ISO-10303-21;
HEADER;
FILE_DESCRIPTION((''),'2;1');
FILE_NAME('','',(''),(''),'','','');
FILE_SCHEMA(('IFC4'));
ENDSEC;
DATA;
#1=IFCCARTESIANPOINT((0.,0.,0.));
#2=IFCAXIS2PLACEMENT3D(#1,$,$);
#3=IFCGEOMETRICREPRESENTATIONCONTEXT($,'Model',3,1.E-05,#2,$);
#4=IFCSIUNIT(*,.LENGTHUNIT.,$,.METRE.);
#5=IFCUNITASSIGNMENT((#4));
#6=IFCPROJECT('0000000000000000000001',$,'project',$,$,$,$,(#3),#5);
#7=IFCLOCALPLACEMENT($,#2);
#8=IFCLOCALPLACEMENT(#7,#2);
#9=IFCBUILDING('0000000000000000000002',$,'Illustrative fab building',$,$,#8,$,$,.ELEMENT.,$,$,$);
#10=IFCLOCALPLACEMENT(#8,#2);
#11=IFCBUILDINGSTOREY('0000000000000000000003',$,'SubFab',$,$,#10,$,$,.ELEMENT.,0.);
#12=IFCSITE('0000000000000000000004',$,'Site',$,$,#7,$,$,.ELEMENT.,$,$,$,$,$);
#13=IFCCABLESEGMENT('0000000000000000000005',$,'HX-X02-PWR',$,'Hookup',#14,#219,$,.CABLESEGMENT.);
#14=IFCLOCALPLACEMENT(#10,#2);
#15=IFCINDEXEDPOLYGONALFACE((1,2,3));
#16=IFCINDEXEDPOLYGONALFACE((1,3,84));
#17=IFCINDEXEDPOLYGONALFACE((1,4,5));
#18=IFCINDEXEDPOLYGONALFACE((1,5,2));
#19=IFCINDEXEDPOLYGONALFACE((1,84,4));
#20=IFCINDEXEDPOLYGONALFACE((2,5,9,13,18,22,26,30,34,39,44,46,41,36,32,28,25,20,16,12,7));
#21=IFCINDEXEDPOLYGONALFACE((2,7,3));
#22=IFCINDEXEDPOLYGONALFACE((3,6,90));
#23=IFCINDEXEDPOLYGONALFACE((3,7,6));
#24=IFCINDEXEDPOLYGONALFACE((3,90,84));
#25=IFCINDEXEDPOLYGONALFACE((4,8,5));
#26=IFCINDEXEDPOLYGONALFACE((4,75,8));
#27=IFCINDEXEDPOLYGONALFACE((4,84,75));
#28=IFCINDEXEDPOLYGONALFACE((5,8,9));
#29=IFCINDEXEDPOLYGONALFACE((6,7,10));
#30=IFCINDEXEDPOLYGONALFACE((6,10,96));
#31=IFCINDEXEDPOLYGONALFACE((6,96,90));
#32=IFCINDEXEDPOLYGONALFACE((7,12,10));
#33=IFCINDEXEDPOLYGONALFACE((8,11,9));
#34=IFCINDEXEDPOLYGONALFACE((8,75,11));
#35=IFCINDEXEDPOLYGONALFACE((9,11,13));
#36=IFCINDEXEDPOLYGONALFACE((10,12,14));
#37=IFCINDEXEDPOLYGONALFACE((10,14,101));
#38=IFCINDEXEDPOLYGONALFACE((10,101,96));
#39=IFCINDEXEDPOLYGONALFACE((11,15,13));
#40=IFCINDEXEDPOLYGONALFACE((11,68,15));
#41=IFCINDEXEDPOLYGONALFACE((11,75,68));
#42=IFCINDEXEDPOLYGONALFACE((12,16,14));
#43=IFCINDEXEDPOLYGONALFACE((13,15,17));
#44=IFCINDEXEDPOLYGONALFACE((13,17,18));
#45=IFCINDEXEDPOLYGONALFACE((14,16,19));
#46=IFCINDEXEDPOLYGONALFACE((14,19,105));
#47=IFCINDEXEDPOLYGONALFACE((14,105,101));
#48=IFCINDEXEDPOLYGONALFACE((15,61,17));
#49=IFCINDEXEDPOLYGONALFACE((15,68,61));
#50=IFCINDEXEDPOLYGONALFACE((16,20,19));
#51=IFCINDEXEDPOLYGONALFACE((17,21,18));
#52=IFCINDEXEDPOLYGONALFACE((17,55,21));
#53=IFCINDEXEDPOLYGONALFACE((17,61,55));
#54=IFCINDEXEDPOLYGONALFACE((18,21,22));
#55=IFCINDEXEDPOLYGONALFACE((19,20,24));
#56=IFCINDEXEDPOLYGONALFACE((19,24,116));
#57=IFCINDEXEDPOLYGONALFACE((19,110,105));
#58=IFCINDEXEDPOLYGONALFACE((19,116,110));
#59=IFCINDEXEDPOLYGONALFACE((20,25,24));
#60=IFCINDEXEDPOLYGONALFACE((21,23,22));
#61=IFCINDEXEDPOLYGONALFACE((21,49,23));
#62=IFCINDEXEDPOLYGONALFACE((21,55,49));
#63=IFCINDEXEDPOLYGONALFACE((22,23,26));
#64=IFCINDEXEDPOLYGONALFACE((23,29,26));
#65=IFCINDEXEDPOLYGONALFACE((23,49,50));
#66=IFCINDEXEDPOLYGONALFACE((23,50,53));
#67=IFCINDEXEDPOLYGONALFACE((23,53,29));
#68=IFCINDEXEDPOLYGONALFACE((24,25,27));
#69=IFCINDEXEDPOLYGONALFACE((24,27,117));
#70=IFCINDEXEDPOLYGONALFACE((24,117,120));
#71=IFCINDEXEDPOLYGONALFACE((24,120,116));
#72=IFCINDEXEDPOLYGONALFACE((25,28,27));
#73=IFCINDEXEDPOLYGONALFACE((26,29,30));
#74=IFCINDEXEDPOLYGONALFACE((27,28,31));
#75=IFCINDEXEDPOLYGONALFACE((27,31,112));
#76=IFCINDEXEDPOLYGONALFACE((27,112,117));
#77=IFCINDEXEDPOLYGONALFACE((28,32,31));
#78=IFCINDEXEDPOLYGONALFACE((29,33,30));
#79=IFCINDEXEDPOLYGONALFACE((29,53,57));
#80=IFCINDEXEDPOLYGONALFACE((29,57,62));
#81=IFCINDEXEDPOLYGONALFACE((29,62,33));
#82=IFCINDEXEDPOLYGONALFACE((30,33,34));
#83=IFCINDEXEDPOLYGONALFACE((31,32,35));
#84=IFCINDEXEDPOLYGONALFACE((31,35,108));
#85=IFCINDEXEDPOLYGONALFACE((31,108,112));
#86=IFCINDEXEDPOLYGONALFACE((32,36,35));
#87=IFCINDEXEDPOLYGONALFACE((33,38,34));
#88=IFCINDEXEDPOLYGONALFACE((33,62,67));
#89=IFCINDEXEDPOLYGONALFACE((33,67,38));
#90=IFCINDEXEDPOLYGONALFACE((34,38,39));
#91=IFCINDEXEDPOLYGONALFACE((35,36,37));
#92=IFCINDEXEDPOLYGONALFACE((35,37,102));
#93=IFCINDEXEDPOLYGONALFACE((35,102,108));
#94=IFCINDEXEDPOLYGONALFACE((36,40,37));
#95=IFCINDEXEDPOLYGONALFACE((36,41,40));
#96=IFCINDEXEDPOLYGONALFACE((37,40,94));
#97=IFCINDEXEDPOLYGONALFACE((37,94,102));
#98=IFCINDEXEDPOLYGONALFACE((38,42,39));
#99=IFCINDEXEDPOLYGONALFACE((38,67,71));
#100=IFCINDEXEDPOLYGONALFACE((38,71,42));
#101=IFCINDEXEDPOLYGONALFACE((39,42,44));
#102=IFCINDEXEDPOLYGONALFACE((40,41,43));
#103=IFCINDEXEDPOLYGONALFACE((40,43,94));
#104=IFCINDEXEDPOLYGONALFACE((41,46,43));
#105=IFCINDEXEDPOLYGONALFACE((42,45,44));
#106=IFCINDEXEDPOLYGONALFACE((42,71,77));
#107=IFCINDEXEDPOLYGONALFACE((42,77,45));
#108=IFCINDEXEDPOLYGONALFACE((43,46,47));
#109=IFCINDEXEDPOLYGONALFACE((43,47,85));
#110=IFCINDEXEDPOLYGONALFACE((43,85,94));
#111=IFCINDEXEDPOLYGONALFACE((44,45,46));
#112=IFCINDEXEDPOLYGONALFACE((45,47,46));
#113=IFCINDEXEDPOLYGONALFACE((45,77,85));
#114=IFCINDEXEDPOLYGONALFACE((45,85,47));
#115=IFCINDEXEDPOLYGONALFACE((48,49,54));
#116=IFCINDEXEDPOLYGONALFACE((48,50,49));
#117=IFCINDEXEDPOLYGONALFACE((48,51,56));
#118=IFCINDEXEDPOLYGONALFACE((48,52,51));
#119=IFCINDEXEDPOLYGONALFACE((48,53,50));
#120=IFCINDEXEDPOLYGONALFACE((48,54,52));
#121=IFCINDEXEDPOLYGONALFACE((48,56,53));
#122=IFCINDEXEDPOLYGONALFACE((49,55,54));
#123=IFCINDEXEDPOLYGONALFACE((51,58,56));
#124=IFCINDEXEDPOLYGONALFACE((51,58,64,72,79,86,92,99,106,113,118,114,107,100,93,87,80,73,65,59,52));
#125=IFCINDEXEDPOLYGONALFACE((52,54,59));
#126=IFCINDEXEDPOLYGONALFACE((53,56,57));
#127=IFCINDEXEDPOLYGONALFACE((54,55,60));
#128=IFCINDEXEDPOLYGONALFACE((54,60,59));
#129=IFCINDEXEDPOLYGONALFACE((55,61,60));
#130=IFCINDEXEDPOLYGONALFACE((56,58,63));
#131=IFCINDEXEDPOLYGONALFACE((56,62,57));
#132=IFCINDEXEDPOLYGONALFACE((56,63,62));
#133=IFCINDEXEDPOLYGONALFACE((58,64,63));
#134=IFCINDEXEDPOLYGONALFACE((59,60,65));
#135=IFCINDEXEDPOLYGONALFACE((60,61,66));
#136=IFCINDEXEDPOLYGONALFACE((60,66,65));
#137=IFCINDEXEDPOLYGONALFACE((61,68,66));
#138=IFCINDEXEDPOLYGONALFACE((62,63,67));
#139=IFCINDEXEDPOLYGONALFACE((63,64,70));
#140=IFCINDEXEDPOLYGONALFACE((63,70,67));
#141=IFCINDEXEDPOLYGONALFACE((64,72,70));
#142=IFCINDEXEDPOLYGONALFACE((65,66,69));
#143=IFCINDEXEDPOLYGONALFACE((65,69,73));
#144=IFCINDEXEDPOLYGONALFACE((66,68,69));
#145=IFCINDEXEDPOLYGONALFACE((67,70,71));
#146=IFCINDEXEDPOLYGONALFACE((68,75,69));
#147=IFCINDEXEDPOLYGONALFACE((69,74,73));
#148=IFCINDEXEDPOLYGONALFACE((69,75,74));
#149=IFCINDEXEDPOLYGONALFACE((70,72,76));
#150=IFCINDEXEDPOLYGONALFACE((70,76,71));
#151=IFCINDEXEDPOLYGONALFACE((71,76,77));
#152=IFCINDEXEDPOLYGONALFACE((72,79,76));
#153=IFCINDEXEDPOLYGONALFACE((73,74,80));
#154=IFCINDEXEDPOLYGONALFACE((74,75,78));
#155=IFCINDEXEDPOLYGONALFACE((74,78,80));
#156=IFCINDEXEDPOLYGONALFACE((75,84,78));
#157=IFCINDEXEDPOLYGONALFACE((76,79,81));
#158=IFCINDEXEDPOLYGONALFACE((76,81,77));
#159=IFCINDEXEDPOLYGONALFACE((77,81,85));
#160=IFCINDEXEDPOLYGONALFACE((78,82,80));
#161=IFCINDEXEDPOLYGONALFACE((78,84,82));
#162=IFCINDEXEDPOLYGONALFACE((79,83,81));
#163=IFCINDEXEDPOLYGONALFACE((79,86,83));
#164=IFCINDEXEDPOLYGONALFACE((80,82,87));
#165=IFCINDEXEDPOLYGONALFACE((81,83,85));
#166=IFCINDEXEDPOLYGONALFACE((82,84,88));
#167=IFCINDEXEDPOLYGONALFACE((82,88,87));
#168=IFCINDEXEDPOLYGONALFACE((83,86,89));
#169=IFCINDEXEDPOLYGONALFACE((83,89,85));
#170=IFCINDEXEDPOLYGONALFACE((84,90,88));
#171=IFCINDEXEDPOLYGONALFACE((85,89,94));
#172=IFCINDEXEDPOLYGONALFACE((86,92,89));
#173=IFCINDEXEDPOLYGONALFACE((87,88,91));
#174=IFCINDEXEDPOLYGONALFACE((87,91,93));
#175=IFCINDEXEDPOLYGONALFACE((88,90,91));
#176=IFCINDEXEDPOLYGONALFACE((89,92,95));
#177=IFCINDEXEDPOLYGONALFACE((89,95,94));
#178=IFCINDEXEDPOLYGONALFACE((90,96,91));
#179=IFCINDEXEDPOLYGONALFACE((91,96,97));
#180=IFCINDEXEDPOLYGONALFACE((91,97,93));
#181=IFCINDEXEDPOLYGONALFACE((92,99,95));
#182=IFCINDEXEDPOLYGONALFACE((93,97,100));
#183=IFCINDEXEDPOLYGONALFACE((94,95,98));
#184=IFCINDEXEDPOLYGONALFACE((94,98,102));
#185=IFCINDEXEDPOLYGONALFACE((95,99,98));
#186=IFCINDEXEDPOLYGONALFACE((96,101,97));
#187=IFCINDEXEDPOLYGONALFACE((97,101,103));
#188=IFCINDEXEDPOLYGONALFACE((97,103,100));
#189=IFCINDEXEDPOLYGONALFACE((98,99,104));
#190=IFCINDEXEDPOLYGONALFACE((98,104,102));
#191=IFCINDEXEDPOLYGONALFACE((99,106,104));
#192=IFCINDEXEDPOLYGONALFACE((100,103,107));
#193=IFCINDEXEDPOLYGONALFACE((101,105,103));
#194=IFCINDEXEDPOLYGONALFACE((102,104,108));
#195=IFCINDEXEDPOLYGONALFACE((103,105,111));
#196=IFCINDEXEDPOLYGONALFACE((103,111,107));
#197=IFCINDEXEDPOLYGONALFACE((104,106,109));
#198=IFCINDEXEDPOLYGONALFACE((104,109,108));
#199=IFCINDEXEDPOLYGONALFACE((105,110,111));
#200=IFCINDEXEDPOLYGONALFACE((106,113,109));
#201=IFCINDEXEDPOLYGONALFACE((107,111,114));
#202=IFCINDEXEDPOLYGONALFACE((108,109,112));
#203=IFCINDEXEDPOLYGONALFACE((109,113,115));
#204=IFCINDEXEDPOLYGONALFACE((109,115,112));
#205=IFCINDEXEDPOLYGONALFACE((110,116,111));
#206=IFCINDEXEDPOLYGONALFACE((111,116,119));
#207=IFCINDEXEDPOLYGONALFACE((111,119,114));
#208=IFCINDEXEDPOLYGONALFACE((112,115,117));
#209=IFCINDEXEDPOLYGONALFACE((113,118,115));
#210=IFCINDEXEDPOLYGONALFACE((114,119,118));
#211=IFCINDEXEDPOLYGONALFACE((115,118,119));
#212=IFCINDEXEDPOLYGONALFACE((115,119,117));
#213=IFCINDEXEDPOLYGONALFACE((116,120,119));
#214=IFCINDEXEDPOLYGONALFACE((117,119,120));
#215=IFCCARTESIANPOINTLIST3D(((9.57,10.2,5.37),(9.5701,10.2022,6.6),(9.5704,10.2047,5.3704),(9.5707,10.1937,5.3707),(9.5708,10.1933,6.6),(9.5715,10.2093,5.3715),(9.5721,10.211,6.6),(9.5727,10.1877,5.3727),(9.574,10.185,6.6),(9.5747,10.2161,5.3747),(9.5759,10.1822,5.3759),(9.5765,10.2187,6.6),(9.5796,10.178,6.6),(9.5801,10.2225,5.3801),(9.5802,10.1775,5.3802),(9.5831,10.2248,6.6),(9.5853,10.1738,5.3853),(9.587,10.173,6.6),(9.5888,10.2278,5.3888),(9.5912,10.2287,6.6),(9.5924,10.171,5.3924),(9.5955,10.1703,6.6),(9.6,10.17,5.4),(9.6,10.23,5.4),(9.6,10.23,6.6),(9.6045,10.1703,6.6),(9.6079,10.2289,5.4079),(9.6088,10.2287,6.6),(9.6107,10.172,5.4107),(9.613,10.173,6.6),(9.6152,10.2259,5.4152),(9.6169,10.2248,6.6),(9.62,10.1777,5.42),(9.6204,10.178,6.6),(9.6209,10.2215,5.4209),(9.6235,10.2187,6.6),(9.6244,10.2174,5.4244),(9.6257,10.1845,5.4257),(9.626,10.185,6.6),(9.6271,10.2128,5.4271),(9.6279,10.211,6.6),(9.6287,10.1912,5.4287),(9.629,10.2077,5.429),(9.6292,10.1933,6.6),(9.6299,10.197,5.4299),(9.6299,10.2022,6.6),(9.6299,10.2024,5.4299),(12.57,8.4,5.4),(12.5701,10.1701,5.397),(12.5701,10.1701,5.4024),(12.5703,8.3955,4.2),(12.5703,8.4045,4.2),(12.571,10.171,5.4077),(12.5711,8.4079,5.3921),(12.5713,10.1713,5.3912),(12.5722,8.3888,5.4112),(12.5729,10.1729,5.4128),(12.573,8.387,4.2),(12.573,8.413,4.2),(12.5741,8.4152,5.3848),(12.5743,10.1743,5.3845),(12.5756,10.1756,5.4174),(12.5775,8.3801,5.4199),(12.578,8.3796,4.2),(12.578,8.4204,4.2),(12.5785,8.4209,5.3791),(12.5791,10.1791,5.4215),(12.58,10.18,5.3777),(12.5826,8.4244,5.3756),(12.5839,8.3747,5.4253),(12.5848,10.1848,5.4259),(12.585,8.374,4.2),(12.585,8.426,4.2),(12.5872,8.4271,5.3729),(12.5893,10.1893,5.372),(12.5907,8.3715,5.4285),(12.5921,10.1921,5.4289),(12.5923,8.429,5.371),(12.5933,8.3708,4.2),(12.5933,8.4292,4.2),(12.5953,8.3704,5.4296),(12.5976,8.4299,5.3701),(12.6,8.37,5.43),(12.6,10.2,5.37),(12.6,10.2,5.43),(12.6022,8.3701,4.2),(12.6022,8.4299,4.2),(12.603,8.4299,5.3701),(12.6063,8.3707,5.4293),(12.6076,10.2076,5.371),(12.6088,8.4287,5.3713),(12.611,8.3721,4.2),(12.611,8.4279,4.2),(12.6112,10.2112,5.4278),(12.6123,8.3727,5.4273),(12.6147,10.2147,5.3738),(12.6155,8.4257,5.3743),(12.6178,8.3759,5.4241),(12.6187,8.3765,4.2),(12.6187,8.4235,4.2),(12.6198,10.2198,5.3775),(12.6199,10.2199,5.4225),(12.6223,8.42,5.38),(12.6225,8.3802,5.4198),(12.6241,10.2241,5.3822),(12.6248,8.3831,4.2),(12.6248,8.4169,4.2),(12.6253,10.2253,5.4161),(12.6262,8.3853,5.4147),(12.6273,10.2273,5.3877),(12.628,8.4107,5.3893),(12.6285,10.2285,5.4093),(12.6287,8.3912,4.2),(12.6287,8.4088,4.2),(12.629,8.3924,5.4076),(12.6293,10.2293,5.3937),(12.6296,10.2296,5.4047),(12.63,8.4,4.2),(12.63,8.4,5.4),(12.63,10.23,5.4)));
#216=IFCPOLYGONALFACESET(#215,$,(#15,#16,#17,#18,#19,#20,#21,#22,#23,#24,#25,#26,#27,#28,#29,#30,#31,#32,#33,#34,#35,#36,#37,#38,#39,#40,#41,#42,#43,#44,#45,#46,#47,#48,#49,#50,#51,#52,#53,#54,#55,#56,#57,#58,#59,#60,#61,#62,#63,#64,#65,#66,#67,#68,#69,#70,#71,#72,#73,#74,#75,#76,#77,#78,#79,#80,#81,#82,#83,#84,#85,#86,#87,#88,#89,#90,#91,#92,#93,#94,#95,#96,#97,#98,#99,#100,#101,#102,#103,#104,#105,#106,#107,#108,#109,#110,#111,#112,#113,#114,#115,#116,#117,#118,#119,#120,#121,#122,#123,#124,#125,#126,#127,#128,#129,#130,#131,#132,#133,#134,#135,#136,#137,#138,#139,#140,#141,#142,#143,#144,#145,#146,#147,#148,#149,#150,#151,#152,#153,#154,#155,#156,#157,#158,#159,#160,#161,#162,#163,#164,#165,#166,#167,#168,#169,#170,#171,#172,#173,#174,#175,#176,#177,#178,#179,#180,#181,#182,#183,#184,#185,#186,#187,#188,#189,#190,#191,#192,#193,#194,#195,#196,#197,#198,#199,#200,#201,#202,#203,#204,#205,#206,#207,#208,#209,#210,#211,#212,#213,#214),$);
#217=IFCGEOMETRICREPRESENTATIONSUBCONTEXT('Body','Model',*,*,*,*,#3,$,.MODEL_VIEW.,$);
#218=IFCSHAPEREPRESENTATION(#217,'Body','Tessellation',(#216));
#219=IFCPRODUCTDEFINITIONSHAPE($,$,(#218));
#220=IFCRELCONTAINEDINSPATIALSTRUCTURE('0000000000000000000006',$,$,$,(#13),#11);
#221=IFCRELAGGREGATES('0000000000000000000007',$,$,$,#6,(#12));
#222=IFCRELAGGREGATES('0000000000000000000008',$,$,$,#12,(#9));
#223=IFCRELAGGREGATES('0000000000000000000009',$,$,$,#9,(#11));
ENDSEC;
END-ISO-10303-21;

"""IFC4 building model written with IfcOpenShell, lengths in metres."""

from ifc_helpers import new_model, entity, si_unit, origin, place, context, subcontext, project, spatial, element, save


model = new_model("IFC4")

# Units and contexts
model_context = context("Model", 3, precision=1e-05, world=origin())
body_context = subcontext(model_context, "Body", "Model", "MODEL_VIEW")
ifc_project = project(units=[si_unit("LENGTHUNIT", "METRE")], contexts=[model_context])

# Site, building, storey
site_placement = place(None, origin())
site = spatial("IfcSite", under=ifc_project, at=site_placement, Name="Site", CompositionType="ELEMENT")
building_placement = place(site_placement, origin())
building = spatial("IfcBuilding", under=site, at=building_placement, Name="Illustrative fab building", CompositionType="ELEMENT")
storey_placement = place(building_placement, origin())
storey = spatial("IfcBuildingStorey", under=building, at=storey_placement, Name="SubFab", CompositionType="ELEMENT", Elevation=0.0)

# Cable segment
cable_segment_1_placement = place(storey_placement, origin())
element("IfcCableSegment", 1, at=cable_segment_1_placement, inside=storey, Name="HX-X02-PWR", ObjectType="Hookup", PredefinedType="CABLESEGMENT", context=body_context, shape_type="AdvancedSweptSolid", body=[
    entity("IfcSweptDiskSolid", entity("IfcPolyline", [entity("IfcCartesianPoint", [12.6, 8.4, 4.2]), entity("IfcCartesianPoint", [12.6, 8.4, 5.4]), entity("IfcCartesianPoint", [12.6, 10.2, 5.4]), entity("IfcCartesianPoint", [9.6, 10.2, 5.4]), entity("IfcCartesianPoint", [9.6, 10.2, 6.6])]), 0.03),
])

save(model, "model.ifc")
